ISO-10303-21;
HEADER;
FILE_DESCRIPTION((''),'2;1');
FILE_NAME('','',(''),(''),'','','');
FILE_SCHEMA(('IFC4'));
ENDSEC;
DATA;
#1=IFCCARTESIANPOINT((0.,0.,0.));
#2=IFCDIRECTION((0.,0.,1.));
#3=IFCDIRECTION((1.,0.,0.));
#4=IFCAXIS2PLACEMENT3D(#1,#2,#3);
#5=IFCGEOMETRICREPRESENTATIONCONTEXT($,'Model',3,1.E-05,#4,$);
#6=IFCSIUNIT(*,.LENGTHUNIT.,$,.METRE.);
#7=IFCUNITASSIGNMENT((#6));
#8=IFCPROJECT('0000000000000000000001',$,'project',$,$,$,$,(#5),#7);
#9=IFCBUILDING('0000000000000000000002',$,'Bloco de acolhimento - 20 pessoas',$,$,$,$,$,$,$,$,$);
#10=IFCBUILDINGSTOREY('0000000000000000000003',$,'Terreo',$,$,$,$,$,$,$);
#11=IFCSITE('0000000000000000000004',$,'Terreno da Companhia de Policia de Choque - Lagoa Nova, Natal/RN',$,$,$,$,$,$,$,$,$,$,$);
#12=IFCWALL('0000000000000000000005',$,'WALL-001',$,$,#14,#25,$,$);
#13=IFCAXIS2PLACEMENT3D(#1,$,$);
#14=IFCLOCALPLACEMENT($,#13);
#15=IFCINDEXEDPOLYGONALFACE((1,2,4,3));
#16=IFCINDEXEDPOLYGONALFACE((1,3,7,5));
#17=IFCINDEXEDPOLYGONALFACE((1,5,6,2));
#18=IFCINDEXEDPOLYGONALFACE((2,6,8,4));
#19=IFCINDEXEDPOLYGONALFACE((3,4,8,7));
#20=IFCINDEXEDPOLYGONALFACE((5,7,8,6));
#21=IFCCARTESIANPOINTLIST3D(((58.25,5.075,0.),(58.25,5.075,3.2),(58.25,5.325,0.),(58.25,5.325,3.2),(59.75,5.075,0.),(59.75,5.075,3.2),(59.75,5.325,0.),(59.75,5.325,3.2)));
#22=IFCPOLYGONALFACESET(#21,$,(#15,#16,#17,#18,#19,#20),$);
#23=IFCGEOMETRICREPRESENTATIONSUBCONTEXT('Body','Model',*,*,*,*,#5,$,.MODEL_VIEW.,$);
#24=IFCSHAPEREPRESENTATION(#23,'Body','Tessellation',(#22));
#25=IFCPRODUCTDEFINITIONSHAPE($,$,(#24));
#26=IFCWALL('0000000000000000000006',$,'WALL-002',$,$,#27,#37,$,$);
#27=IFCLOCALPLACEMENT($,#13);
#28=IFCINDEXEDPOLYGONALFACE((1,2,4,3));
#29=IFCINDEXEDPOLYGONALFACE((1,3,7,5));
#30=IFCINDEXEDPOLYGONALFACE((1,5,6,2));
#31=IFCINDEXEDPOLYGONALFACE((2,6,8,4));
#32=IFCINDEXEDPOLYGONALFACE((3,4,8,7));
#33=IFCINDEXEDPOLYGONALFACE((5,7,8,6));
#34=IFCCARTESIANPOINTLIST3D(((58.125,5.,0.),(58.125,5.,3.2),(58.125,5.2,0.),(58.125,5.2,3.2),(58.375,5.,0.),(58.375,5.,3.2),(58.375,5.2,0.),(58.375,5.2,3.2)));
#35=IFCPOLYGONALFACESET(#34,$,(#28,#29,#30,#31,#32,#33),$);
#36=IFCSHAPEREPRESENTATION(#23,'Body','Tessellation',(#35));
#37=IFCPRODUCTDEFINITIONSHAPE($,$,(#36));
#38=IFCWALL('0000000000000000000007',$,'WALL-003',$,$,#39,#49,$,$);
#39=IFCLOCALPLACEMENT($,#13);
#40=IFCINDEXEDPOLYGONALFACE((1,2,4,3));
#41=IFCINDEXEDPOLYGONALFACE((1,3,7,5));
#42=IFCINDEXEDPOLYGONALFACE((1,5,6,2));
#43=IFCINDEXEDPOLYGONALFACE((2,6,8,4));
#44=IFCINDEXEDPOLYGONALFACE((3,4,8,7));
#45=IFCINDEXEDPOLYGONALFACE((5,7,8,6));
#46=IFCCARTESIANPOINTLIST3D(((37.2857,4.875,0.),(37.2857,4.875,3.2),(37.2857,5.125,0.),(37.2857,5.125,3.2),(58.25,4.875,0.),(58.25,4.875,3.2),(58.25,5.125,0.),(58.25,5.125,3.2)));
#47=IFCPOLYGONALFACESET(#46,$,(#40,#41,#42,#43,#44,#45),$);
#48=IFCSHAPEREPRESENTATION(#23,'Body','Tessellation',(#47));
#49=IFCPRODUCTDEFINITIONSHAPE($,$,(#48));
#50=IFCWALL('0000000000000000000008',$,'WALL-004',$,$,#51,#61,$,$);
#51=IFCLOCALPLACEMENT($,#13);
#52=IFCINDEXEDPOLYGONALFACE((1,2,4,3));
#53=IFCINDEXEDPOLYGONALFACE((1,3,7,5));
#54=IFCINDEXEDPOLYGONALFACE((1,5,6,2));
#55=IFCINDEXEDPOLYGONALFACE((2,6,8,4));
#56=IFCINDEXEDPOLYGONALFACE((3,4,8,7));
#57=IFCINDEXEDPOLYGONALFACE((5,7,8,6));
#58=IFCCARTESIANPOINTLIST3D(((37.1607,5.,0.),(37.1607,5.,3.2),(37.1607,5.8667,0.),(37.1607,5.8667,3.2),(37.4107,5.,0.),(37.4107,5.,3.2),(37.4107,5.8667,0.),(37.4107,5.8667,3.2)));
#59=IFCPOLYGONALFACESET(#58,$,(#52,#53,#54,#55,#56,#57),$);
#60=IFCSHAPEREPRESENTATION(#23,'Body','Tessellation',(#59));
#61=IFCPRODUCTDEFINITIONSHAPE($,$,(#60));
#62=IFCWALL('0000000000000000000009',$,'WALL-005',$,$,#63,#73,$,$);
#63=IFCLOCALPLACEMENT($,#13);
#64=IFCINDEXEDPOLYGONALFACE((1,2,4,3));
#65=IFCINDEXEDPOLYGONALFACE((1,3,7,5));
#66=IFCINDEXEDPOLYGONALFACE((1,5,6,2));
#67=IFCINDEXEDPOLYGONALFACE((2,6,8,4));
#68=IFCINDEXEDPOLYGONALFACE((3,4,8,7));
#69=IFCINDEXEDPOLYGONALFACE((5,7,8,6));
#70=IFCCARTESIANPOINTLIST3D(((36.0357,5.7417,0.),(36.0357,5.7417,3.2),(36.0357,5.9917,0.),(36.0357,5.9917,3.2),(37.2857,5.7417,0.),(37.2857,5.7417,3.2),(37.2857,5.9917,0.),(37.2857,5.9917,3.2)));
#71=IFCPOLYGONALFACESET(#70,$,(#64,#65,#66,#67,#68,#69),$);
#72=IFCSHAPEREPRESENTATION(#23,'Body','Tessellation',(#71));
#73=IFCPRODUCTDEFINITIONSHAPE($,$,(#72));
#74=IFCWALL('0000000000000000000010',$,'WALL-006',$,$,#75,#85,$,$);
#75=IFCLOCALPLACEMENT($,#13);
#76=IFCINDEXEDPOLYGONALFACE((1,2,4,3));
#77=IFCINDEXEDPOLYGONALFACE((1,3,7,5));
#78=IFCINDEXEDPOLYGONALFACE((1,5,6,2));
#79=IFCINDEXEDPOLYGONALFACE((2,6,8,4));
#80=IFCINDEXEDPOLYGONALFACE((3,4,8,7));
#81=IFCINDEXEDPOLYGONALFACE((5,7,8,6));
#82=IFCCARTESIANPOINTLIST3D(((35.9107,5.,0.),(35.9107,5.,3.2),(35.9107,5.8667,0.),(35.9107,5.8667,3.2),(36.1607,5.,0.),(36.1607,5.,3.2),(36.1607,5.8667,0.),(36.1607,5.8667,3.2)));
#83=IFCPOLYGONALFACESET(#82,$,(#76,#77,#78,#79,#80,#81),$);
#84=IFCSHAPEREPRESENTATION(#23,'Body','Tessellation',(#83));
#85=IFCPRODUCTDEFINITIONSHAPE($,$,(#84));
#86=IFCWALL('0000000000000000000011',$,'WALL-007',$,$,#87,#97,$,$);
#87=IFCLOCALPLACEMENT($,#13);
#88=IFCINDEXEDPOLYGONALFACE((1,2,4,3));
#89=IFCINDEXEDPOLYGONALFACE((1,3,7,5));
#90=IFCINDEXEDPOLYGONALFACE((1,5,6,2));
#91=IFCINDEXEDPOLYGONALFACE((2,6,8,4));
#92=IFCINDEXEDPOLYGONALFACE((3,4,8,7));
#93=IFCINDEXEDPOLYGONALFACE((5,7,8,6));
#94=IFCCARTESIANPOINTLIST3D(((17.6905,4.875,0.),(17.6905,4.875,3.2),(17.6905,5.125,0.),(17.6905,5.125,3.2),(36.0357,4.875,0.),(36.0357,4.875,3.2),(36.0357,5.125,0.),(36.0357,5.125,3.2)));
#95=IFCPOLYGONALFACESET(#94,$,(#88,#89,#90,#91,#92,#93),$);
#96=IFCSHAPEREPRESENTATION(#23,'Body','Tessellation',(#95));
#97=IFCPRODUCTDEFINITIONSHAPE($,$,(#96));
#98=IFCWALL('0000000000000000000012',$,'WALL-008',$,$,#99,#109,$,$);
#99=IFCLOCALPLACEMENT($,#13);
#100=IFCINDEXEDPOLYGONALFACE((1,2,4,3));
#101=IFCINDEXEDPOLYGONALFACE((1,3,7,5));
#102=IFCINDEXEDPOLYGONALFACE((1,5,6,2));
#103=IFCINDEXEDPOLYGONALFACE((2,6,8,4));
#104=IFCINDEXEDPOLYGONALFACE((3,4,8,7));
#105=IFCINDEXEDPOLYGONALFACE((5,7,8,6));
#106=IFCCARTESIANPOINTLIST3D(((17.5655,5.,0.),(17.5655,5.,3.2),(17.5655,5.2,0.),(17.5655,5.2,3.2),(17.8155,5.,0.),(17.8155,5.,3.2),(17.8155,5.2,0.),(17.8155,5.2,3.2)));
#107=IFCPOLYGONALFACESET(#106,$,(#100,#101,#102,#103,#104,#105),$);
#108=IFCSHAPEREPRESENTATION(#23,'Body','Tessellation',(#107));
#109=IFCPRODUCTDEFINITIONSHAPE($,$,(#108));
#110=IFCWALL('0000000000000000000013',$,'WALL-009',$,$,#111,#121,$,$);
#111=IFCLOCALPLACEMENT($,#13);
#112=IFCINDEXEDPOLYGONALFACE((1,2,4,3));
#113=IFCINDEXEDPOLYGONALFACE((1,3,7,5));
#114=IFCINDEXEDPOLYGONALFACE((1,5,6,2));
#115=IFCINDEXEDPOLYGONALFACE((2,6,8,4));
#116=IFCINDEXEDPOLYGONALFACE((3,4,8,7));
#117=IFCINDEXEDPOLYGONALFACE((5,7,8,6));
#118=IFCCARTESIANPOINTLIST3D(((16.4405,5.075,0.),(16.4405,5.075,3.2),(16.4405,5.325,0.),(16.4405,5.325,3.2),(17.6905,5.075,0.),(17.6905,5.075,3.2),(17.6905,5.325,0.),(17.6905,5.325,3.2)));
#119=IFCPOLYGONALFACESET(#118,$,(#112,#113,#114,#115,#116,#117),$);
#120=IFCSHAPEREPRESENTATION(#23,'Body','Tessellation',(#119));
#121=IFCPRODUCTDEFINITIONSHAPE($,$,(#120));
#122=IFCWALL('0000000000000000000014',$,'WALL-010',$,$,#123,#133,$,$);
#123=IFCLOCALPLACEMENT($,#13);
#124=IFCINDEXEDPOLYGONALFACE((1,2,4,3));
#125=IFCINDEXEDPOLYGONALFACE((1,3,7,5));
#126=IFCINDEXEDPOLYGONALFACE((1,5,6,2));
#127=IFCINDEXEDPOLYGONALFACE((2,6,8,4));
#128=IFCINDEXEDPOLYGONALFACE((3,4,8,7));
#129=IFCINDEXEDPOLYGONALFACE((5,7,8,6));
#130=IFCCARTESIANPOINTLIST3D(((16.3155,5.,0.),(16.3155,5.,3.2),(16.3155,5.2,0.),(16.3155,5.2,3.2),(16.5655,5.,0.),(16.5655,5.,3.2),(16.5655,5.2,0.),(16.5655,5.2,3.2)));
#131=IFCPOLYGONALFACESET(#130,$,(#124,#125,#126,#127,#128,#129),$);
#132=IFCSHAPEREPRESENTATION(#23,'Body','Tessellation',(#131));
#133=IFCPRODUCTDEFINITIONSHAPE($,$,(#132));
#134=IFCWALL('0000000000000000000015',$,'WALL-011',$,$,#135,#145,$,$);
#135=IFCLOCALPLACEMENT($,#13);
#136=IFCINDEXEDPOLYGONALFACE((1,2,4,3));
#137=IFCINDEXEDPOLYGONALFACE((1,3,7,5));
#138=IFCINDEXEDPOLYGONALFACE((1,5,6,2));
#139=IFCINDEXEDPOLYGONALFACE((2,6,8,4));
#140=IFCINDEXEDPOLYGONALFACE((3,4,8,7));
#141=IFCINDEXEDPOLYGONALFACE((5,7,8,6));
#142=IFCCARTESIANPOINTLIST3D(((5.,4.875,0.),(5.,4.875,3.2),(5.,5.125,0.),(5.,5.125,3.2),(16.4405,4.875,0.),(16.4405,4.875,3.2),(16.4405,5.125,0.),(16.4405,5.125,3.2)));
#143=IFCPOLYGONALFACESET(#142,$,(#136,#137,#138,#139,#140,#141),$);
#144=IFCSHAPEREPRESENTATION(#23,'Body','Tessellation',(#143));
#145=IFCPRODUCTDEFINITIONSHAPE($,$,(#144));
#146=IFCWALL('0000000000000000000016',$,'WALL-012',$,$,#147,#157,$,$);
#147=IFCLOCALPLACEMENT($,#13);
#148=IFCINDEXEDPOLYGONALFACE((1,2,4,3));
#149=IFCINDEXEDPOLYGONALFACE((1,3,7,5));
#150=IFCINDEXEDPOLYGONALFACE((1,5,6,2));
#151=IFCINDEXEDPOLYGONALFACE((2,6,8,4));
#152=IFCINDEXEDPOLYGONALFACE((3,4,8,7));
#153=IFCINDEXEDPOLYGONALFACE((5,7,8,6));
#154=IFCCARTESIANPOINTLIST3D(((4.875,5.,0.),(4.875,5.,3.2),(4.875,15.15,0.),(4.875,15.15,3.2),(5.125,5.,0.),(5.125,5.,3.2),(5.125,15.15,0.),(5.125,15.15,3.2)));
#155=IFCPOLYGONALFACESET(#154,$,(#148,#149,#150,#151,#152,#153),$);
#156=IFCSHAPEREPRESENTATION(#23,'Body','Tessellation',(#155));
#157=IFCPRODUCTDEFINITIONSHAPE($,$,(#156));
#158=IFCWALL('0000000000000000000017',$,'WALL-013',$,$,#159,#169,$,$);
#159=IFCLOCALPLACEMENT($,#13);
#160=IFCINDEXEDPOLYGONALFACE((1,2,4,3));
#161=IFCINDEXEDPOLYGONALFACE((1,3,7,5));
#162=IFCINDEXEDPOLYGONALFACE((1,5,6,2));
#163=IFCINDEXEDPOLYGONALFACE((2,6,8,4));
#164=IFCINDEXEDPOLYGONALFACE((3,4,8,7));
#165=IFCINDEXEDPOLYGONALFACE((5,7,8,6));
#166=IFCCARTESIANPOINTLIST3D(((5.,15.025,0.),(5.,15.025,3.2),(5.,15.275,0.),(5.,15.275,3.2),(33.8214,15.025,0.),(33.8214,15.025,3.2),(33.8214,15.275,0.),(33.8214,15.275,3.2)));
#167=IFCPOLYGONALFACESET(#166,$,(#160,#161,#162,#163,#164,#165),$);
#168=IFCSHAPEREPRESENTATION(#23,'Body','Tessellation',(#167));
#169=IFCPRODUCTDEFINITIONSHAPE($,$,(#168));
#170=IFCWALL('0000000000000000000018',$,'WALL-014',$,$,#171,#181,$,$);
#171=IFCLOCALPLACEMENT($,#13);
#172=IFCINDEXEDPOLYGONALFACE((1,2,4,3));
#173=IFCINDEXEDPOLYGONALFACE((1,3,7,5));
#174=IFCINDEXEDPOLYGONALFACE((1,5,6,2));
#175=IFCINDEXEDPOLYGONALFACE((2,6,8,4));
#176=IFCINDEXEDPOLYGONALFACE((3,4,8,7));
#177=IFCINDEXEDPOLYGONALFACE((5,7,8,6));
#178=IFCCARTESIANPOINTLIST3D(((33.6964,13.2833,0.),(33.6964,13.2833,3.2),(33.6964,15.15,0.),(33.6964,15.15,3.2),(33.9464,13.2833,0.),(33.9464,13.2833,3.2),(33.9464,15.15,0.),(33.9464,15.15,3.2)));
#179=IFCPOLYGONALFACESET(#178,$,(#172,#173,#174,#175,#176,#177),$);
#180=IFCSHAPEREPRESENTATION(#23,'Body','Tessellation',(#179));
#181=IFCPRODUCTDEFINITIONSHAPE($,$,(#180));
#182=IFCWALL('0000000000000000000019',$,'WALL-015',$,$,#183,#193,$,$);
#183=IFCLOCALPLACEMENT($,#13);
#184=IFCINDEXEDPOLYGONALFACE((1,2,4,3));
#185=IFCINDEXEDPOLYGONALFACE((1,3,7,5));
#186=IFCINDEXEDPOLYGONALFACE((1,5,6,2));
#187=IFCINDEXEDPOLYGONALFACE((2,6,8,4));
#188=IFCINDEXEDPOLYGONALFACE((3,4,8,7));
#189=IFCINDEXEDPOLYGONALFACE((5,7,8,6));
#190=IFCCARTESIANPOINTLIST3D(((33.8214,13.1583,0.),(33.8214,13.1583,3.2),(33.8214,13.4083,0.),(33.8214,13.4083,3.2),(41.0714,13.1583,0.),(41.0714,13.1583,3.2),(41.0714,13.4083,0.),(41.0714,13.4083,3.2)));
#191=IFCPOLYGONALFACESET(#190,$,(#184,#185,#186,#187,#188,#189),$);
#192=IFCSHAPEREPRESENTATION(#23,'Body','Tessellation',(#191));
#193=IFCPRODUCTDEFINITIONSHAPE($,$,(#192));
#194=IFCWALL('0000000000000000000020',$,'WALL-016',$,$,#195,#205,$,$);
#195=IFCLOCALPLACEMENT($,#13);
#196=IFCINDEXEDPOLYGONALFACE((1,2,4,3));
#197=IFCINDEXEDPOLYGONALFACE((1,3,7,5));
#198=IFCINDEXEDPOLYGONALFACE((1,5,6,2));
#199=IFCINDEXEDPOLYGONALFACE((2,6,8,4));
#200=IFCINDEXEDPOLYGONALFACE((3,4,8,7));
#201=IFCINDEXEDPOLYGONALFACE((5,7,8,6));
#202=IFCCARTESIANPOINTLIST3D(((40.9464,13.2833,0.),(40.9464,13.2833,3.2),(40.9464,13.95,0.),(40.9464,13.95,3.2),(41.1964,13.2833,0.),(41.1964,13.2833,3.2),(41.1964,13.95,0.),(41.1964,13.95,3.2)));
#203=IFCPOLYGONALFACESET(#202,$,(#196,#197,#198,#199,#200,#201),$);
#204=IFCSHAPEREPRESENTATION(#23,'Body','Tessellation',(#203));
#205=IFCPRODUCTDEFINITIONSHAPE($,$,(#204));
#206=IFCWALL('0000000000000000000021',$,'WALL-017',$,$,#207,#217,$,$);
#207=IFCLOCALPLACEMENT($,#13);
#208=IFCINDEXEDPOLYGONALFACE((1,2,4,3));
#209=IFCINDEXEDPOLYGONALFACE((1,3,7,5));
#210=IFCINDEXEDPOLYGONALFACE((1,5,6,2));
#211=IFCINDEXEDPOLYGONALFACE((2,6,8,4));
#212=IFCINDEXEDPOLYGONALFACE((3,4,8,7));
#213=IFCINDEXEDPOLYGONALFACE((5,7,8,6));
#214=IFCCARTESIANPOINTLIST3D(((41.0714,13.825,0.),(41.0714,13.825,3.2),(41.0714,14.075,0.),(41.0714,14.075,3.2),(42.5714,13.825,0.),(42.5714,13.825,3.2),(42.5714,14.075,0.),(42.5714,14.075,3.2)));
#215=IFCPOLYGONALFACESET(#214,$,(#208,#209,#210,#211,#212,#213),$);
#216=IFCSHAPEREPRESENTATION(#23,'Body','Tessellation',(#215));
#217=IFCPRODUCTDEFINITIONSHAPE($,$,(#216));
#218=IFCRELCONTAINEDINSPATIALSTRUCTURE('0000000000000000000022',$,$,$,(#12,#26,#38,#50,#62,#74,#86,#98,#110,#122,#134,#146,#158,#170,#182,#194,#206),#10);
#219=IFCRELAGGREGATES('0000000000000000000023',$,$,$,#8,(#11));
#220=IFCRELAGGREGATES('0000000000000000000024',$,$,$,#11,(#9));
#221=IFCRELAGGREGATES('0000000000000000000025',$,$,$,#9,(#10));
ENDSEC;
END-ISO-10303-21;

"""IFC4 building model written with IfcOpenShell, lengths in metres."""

from ifc_helpers import new_model, si_unit, origin_with_axes, place, context, subcontext, project, spatial, polyline, outline, extrude, element, save


model = new_model("IFC4")

# Units and contexts
model_context = context("Model", 3, precision=1e-05, world=origin_with_axes())
body_context = subcontext(model_context, "Body", "Model", "MODEL_VIEW")
ifc_project = project(units=[si_unit("LENGTHUNIT", "METRE")], contexts=[model_context])

# Site, building, storey
site = spatial("IfcSite", under=ifc_project, Name="Terreno da Companhia de Policia de Choque - Lagoa Nova, Natal/RN")
building = spatial("IfcBuilding", under=site, Name="Bloco de acolhimento - 20 pessoas")
storey = spatial("IfcBuildingStorey", under=building, Name="Terreo")

# Walls
wall_1_placement = place(None, origin_with_axes())
element("IfcWall", 1, at=wall_1_placement, inside=storey, Name="WALL-001", context=body_context, shape_type="SweptSolid", body=[
    extrude(outline(polyline([(59.75, 5.075, 0.0), (59.75, 5.325, 0.0), (58.25, 5.325, 0.0), (58.25, 5.075, 0.0), (59.75, 5.075, 0.0)])), None, (0.0, 0.0, 1.0), 3.2),
])
wall_2_placement = place(None, origin_with_axes())
element("IfcWall", 2, at=wall_2_placement, inside=storey, Name="WALL-002", context=body_context, shape_type="SweptSolid", body=[
    extrude(outline(polyline([(58.375, 5.0, 0.0), (58.375, 5.2, 0.0), (58.125, 5.2, 0.0), (58.125, 5.0, 0.0), (58.375, 5.0, 0.0)])), None, (0.0, 0.0, 1.0), 3.2),
])
wall_3_placement = place(None, origin_with_axes())
element("IfcWall", 3, at=wall_3_placement, inside=storey, Name="WALL-003", context=body_context, shape_type="SweptSolid", body=[
    extrude(outline(polyline([(58.25, 4.875, 0.0), (58.25, 5.125, 0.0), (37.2857, 5.125, 0.0), (37.2857, 4.875, 0.0), (58.25, 4.875, 0.0)])), None, (0.0, 0.0, 1.0), 3.2),
])
wall_4_placement = place(None, origin_with_axes())
element("IfcWall", 4, at=wall_4_placement, inside=storey, Name="WALL-004", context=body_context, shape_type="SweptSolid", body=[
    extrude(outline(polyline([(37.4107, 5.0, 0.0), (37.4107, 5.8667, 0.0), (37.1607, 5.8667, 0.0), (37.1607, 5.0, 0.0), (37.4107, 5.0, 0.0)])), None, (0.0, 0.0, 1.0), 3.2),
])
wall_5_placement = place(None, origin_with_axes())
element("IfcWall", 5, at=wall_5_placement, inside=storey, Name="WALL-005", context=body_context, shape_type="SweptSolid", body=[
    extrude(outline(polyline([(37.2857, 5.7417, 0.0), (37.2857, 5.9917, 0.0), (36.0357, 5.9917, 0.0), (36.0357, 5.7417, 0.0), (37.2857, 5.7417, 0.0)])), None, (0.0, 0.0, 1.0), 3.2),
])
wall_6_placement = place(None, origin_with_axes())
element("IfcWall", 6, at=wall_6_placement, inside=storey, Name="WALL-006", context=body_context, shape_type="SweptSolid", body=[
    extrude(outline(polyline([(36.1607, 5.0, 0.0), (36.1607, 5.8667, 0.0), (35.9107, 5.8667, 0.0), (35.9107, 5.0, 0.0), (36.1607, 5.0, 0.0)])), None, (0.0, 0.0, 1.0), 3.2),
])
wall_7_placement = place(None, origin_with_axes())
element("IfcWall", 7, at=wall_7_placement, inside=storey, Name="WALL-007", context=body_context, shape_type="SweptSolid", body=[
    extrude(outline(polyline([(36.0357, 4.875, 0.0), (36.0357, 5.125, 0.0), (17.6905, 5.125, 0.0), (17.6905, 4.875, 0.0), (36.0357, 4.875, 0.0)])), None, (0.0, 0.0, 1.0), 3.2),
])
wall_8_placement = place(None, origin_with_axes())
element("IfcWall", 8, at=wall_8_placement, inside=storey, Name="WALL-008", context=body_context, shape_type="SweptSolid", body=[
    extrude(outline(polyline([(17.8155, 5.0, 0.0), (17.8155, 5.2, 0.0), (17.5655, 5.2, 0.0), (17.5655, 5.0, 0.0), (17.8155, 5.0, 0.0)])), None, (0.0, 0.0, 1.0), 3.2),
])
wall_9_placement = place(None, origin_with_axes())
element("IfcWall", 9, at=wall_9_placement, inside=storey, Name="WALL-009", context=body_context, shape_type="SweptSolid", body=[
    extrude(outline(polyline([(17.6905, 5.075, 0.0), (17.6905, 5.325, 0.0), (16.4405, 5.325, 0.0), (16.4405, 5.075, 0.0), (17.6905, 5.075, 0.0)])), None, (0.0, 0.0, 1.0), 3.2),
])
wall_10_placement = place(None, origin_with_axes())
element("IfcWall", 10, at=wall_10_placement, inside=storey, Name="WALL-010", context=body_context, shape_type="SweptSolid", body=[
    extrude(outline(polyline([(16.5655, 5.0, 0.0), (16.5655, 5.2, 0.0), (16.3155, 5.2, 0.0), (16.3155, 5.0, 0.0), (16.5655, 5.0, 0.0)])), None, (0.0, 0.0, 1.0), 3.2),
])
wall_11_placement = place(None, origin_with_axes())
element("IfcWall", 11, at=wall_11_placement, inside=storey, Name="WALL-011", context=body_context, shape_type="SweptSolid", body=[
    extrude(outline(polyline([(16.4405, 4.875, 0.0), (16.4405, 5.125, 0.0), (5.0, 5.125, 0.0), (5.0, 4.875, 0.0), (16.4405, 4.875, 0.0)])), None, (0.0, 0.0, 1.0), 3.2),
])
wall_12_placement = place(None, origin_with_axes())
element("IfcWall", 12, at=wall_12_placement, inside=storey, Name="WALL-012", context=body_context, shape_type="SweptSolid", body=[
    extrude(outline(polyline([(5.125, 5.0, 0.0), (5.125, 15.15, 0.0), (4.875, 15.15, 0.0), (4.875, 5.0, 0.0), (5.125, 5.0, 0.0)])), None, (0.0, 0.0, 1.0), 3.2),
])
wall_13_placement = place(None, origin_with_axes())
element("IfcWall", 13, at=wall_13_placement, inside=storey, Name="WALL-013", context=body_context, shape_type="SweptSolid", body=[
    extrude(outline(polyline([(33.8214, 15.025, 0.0), (33.8214, 15.275, 0.0), (5.0, 15.275, 0.0), (5.0, 15.025, 0.0), (33.8214, 15.025, 0.0)])), None, (0.0, 0.0, 1.0), 3.2),
])
wall_14_placement = place(None, origin_with_axes())
element("IfcWall", 14, at=wall_14_placement, inside=storey, Name="WALL-014", context=body_context, shape_type="SweptSolid", body=[
    extrude(outline(polyline([(33.9464, 13.2833, 0.0), (33.9464, 15.15, 0.0), (33.6964, 15.15, 0.0), (33.6964, 13.2833, 0.0), (33.9464, 13.2833, 0.0)])), None, (0.0, 0.0, 1.0), 3.2),
])
wall_15_placement = place(None, origin_with_axes())
element("IfcWall", 15, at=wall_15_placement, inside=storey, Name="WALL-015", context=body_context, shape_type="SweptSolid", body=[
    extrude(outline(polyline([(41.0714, 13.1583, 0.0), (41.0714, 13.4083, 0.0), (33.8214, 13.4083, 0.0), (33.8214, 13.1583, 0.0), (41.0714, 13.1583, 0.0)])), None, (0.0, 0.0, 1.0), 3.2),
])
wall_16_placement = place(None, origin_with_axes())
element("IfcWall", 16, at=wall_16_placement, inside=storey, Name="WALL-016", context=body_context, shape_type="SweptSolid", body=[
    extrude(outline(polyline([(41.1964, 13.2833, 0.0), (41.1964, 13.95, 0.0), (40.9464, 13.95, 0.0), (40.9464, 13.2833, 0.0), (41.1964, 13.2833, 0.0)])), None, (0.0, 0.0, 1.0), 3.2),
])
wall_17_placement = place(None, origin_with_axes())
element("IfcWall", 17, at=wall_17_placement, inside=storey, Name="WALL-017", context=body_context, shape_type="SweptSolid", body=[
    extrude(outline(polyline([(42.5714, 13.825, 0.0), (42.5714, 14.075, 0.0), (41.0714, 14.075, 0.0), (41.0714, 13.825, 0.0), (42.5714, 13.825, 0.0)])), None, (0.0, 0.0, 1.0), 3.2),
])

save(model, "model.ifc")
